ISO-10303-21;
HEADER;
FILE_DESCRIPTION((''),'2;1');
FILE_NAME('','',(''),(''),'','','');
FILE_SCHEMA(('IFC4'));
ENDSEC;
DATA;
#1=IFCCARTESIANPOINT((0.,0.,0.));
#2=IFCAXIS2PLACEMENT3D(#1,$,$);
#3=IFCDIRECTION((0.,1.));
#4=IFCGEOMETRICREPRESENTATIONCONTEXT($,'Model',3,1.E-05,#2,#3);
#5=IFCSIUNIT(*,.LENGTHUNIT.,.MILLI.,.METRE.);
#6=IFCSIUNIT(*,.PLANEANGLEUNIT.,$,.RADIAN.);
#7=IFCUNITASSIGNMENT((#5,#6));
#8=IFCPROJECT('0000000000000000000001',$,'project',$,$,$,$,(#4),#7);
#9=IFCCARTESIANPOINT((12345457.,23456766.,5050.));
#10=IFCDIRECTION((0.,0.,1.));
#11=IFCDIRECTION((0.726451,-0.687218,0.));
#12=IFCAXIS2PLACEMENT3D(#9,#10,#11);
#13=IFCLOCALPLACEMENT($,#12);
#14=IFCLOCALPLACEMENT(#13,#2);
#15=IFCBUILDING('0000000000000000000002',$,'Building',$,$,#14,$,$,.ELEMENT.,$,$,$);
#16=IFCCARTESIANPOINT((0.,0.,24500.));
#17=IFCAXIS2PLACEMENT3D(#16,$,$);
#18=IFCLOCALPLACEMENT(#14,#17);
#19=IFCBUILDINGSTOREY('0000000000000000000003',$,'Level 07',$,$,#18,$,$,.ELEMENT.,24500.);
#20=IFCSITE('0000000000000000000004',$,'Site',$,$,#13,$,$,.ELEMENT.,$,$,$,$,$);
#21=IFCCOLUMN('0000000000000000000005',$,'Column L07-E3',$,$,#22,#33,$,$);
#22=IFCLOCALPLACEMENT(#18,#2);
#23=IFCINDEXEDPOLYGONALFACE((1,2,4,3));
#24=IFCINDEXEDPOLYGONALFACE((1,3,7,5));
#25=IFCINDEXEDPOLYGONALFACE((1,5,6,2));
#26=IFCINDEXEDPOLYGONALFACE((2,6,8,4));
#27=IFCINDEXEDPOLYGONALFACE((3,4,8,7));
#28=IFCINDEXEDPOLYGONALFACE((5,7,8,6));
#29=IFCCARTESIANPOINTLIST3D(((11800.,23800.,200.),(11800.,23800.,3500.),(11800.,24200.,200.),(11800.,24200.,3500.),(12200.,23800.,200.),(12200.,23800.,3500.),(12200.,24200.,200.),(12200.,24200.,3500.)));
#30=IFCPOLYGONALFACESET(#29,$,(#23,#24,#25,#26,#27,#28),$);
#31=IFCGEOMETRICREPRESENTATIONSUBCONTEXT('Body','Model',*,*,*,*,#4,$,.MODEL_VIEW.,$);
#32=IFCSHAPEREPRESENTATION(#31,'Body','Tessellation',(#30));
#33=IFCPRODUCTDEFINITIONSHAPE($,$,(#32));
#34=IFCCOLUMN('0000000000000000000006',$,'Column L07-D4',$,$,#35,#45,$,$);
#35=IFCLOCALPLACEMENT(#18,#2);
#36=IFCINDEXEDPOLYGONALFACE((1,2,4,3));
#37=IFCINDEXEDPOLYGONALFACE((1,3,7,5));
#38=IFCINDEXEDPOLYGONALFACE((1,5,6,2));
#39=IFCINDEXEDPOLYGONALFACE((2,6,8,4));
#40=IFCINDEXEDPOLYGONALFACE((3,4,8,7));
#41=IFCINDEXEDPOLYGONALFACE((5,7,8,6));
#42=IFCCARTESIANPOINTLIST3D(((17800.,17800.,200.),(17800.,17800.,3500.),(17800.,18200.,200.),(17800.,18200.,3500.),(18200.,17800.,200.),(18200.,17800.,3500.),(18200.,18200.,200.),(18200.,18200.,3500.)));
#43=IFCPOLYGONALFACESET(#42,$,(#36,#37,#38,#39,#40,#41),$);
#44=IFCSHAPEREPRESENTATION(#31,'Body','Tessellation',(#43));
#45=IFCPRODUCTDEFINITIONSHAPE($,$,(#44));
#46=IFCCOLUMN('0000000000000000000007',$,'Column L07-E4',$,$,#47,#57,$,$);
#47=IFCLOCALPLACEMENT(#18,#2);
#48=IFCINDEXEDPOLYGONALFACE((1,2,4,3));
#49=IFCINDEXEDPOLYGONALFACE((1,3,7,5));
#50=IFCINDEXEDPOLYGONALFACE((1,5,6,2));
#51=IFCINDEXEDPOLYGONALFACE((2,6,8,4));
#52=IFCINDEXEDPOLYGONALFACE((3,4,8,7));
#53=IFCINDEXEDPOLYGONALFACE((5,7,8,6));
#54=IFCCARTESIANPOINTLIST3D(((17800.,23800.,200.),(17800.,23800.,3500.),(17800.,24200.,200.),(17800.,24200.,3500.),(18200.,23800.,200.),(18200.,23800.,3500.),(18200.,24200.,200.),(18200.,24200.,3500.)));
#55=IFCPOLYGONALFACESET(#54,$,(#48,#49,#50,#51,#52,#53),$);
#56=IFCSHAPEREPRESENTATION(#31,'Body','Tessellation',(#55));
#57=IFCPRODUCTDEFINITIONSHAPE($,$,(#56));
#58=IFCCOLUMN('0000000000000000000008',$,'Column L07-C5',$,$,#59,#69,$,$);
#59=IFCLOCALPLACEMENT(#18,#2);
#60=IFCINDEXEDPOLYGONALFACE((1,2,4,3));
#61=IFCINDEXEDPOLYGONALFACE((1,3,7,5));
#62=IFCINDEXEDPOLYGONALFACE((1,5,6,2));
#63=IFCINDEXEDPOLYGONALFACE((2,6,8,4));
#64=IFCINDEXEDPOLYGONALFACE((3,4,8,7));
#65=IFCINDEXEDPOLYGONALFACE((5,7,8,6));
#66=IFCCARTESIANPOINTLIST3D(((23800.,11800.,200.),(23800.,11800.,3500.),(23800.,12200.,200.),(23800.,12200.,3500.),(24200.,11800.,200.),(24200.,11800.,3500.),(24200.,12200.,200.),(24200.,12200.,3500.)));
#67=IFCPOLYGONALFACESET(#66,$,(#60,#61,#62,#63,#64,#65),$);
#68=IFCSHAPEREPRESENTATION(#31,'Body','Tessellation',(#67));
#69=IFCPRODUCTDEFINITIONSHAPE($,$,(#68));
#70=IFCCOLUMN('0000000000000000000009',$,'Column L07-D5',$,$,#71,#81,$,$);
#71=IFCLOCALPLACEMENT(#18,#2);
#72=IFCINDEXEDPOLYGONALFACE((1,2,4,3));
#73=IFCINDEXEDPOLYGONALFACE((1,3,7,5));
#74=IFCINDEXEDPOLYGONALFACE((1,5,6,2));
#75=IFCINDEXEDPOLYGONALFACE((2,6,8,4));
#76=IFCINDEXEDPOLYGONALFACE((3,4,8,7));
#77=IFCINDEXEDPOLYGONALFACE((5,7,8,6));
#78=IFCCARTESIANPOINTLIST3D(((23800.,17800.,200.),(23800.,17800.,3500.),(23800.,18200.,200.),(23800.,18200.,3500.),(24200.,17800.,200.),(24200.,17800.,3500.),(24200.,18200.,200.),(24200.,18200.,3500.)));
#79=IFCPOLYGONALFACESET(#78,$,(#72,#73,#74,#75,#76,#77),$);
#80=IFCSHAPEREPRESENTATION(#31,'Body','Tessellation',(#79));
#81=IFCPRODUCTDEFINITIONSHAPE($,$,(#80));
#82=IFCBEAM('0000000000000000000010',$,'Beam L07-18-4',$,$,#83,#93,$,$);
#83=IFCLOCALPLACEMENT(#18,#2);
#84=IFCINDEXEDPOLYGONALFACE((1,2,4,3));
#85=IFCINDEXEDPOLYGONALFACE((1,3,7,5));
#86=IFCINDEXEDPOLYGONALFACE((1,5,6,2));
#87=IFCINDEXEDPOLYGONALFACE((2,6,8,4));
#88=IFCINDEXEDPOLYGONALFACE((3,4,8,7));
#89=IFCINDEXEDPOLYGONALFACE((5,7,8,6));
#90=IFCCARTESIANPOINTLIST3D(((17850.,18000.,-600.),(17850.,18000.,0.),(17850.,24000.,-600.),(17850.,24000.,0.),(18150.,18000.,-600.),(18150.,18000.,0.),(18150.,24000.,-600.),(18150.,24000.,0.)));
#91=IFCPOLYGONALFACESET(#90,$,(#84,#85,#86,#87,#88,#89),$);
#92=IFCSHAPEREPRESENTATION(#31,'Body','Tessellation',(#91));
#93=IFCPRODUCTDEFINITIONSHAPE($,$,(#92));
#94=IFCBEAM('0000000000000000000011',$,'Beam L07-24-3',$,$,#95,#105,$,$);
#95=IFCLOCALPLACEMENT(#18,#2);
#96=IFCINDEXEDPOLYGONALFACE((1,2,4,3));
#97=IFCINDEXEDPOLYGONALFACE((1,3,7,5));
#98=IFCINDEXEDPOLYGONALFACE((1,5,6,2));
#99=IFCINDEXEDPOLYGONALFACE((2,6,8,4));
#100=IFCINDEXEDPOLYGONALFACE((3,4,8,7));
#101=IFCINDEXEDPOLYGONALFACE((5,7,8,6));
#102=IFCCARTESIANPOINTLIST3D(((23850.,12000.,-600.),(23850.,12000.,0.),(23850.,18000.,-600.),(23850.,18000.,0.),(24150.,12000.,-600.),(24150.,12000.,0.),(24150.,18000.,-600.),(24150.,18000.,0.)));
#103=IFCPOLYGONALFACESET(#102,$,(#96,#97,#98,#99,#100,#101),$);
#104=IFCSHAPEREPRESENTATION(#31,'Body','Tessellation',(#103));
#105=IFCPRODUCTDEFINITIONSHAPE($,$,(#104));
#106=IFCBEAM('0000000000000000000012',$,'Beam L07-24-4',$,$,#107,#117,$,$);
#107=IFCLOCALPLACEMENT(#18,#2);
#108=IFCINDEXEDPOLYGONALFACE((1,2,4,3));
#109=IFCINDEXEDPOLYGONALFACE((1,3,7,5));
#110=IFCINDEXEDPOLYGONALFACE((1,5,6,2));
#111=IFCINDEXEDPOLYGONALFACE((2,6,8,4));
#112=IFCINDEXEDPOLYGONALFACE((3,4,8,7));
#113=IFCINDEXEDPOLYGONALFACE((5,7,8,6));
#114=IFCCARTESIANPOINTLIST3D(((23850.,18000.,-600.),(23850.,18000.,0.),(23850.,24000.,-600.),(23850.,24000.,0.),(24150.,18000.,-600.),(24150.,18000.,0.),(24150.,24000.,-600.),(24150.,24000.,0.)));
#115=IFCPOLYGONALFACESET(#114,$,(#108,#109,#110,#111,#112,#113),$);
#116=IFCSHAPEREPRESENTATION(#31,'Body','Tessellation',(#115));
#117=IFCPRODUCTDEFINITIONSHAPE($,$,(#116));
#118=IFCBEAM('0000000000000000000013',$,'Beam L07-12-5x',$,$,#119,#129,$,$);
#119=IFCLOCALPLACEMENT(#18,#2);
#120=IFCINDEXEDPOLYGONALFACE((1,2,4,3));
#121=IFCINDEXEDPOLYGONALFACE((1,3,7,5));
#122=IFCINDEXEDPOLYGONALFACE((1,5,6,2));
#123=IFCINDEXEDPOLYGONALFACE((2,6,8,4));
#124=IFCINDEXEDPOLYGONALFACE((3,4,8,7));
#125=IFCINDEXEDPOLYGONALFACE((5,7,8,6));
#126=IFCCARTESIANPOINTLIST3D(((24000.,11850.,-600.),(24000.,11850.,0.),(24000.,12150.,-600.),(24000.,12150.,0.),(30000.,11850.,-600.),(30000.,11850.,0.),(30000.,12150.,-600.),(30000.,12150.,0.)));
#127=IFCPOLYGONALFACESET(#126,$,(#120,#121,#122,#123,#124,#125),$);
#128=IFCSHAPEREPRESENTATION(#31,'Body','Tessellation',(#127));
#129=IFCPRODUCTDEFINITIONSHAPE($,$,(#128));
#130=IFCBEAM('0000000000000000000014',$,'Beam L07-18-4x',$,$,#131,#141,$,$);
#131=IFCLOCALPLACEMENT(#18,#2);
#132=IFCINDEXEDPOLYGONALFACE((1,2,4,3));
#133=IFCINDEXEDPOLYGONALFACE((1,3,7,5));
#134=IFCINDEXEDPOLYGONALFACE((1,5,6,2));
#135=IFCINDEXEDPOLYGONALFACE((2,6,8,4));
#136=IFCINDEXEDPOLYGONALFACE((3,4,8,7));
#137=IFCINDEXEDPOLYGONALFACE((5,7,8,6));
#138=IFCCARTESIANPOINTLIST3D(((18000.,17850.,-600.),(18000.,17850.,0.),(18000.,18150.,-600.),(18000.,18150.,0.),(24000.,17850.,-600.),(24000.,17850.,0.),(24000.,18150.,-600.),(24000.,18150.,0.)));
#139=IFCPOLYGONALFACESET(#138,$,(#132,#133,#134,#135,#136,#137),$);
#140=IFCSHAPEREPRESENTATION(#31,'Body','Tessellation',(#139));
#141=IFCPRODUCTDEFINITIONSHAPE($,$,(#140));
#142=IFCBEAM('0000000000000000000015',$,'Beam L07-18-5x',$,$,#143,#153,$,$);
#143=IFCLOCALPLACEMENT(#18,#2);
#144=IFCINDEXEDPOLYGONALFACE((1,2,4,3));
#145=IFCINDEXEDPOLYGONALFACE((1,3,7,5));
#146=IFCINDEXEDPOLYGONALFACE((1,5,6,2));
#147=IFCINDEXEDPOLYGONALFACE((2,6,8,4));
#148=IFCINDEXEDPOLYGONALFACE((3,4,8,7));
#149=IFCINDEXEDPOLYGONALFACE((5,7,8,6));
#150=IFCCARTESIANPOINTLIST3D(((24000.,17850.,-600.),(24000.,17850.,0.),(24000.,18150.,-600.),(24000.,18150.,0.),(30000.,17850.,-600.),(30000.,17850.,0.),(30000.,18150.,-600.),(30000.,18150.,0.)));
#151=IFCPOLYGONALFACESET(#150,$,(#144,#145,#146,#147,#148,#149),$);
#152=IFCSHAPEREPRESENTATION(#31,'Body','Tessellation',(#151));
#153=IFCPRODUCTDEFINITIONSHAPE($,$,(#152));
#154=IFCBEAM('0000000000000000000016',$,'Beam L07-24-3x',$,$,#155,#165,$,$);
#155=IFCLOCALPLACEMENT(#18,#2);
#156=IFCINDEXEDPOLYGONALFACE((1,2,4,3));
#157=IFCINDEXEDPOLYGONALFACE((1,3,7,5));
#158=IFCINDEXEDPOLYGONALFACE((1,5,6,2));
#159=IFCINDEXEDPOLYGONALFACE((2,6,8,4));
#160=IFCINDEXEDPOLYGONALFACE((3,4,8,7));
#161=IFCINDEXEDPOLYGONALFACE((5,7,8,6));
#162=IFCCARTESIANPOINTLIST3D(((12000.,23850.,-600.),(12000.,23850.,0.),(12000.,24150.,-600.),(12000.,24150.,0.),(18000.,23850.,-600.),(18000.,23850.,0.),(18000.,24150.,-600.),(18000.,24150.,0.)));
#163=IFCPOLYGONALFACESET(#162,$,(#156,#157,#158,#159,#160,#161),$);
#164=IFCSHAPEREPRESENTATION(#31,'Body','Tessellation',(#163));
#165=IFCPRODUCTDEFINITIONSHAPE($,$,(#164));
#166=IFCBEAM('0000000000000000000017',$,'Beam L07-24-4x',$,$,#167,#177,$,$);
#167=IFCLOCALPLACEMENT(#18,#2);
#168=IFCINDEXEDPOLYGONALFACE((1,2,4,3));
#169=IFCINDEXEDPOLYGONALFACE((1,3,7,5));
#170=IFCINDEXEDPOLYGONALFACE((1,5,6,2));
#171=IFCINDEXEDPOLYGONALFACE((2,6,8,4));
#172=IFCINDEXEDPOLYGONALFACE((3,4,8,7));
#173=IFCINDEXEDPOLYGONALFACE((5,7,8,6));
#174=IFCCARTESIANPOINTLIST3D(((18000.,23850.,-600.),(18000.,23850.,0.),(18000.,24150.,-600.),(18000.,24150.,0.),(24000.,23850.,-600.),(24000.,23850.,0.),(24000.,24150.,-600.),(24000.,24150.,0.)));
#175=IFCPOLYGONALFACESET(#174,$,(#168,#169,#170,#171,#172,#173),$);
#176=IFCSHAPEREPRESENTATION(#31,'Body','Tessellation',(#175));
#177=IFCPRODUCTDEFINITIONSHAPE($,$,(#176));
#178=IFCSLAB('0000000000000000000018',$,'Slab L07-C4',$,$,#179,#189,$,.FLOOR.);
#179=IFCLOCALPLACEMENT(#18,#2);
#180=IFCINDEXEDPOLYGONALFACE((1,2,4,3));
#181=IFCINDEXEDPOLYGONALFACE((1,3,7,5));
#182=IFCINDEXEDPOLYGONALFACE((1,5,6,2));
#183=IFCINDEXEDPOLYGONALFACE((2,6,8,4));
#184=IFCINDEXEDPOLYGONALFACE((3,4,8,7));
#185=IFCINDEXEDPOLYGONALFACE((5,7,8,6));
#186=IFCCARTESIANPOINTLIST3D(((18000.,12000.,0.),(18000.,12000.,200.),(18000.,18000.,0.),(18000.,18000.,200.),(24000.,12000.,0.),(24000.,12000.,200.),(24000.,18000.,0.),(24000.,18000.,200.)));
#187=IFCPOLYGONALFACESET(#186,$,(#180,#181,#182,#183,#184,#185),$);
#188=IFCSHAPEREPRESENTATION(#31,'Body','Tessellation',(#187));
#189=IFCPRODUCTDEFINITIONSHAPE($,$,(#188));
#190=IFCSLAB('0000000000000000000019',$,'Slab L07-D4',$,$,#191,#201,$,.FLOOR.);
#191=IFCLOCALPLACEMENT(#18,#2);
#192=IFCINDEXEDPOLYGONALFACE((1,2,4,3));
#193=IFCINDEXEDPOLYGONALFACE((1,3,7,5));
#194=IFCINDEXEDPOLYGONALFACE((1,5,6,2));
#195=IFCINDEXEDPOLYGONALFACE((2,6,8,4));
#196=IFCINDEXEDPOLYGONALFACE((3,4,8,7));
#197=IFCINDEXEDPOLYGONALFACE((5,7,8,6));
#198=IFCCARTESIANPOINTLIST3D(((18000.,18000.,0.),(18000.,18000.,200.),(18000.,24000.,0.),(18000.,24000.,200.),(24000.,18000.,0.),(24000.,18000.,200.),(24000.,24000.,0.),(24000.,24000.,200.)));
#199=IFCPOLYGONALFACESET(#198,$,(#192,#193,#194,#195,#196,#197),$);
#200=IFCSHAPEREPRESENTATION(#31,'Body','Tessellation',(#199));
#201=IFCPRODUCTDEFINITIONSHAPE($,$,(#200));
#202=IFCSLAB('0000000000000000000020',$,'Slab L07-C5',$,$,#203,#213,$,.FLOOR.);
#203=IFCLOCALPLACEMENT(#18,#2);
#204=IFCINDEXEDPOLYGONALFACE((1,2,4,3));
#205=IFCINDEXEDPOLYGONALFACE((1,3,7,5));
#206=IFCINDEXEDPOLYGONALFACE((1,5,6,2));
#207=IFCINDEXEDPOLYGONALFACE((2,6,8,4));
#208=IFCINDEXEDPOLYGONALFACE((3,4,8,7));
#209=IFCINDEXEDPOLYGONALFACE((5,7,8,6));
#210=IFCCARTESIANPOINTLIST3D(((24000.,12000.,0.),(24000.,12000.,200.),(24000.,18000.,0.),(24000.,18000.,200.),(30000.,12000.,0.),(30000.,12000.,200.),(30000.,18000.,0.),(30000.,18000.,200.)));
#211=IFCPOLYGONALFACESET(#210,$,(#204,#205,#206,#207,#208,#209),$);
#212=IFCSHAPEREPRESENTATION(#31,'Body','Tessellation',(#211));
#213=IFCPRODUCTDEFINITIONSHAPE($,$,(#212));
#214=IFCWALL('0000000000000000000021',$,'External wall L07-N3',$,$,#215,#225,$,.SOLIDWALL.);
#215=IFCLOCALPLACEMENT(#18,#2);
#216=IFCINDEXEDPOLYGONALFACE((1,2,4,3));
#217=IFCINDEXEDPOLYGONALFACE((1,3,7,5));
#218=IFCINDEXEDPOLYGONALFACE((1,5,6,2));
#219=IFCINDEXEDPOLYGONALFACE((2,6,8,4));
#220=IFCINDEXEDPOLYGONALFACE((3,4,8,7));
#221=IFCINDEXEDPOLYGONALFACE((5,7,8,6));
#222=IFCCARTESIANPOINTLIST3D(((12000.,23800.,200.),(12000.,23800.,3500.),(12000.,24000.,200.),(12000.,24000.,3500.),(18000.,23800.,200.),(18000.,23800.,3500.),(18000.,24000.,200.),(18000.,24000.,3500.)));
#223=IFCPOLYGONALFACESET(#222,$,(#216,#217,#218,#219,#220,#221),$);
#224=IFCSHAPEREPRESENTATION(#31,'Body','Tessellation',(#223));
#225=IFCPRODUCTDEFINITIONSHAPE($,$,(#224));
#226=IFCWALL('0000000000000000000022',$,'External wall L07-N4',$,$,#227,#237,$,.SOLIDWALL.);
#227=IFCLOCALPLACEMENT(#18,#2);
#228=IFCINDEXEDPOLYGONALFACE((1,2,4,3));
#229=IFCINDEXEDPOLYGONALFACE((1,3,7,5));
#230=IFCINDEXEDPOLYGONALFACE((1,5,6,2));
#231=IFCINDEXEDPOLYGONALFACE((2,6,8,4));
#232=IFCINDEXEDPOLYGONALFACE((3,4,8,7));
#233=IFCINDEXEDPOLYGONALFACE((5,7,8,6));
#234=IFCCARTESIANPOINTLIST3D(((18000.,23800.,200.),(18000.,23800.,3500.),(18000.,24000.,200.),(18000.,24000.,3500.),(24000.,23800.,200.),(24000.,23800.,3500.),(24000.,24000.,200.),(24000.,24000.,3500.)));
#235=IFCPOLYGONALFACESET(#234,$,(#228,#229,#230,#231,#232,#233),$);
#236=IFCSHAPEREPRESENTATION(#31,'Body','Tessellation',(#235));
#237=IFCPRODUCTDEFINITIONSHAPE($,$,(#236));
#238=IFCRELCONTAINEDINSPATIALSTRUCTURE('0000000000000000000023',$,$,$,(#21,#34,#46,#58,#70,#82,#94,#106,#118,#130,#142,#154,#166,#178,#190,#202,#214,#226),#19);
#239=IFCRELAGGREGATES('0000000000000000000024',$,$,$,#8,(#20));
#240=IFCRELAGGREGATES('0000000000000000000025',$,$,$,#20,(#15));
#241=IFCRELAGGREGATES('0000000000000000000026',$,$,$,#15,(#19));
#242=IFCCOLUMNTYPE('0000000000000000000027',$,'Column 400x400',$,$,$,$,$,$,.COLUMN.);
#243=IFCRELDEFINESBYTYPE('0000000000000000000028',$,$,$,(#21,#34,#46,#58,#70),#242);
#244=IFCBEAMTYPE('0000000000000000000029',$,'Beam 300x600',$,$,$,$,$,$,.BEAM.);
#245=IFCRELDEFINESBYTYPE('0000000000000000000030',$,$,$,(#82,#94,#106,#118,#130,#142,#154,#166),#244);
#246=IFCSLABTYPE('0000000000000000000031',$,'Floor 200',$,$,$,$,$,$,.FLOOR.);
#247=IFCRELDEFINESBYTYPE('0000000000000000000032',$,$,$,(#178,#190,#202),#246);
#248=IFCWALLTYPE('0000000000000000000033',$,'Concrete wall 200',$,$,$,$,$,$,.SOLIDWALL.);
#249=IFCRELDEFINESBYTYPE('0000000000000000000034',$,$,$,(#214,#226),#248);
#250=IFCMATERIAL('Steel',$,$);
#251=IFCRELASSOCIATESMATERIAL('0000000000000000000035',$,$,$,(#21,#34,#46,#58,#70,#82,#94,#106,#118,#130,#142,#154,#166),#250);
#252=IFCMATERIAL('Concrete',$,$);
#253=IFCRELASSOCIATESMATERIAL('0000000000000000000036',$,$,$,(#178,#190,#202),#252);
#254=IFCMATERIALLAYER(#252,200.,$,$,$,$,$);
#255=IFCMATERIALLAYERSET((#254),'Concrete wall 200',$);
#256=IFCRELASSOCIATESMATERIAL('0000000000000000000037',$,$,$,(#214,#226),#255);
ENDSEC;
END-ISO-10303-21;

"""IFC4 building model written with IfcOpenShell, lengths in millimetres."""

from ifc_helpers import new_model, si_unit, direction, frame, origin, place, context, subcontext, project, spatial, rectangle, extrude, material, layer, layer_set, layer_usage, type_object, element, save


model = new_model("IFC4")

# Units and contexts
model_context = context("Model", 3, precision=1e-05, world=origin(), true_north=direction((0.0, 1.0)))
body_context = subcontext(model_context, "Body", "Model", "MODEL_VIEW")
ifc_project = project(units=[si_unit("LENGTHUNIT", "METRE", prefix="MILLI"), si_unit("PLANEANGLEUNIT", "RADIAN")], contexts=[model_context])

# Site, building, storey
site_placement = place(None, frame((12345457.0, 23456766.0, 5050.0), z_axis=(0.0, 0.0, 1.0), x_axis=(0.726451, -0.687218, 0.0)))
site = spatial("IfcSite", under=ifc_project, at=site_placement, Name="Site", CompositionType="ELEMENT")
building_placement = place(site_placement, origin())
building = spatial("IfcBuilding", under=site, at=building_placement, Name="Building", CompositionType="ELEMENT")
storey_placement = place(building_placement, frame((0.0, 0.0, 24500.0)))
storey = spatial("IfcBuildingStorey", under=building, at=storey_placement, Name="Level 07", CompositionType="ELEMENT", Elevation=24500.0)

# Columns
ifc_material_1 = material(Name="Steel")
column_type = type_object("IfcColumnType", Name="Column 400x400", PredefinedType="COLUMN")
for number, where, name in (
    (1, (11800.0, 23800.0, 200.0), "Column L07-E3"),
    (2, (17800.0, 17800.0, 200.0), "Column L07-D4"),
    (3, (17800.0, 23800.0, 200.0), "Column L07-E4"),
    (4, (23800.0, 11800.0, 200.0), "Column L07-C5"),
    (5, (23800.0, 17800.0, 200.0), "Column L07-D5"),
):
    element("IfcColumn", number, at=place(storey_placement, frame(where)), inside=storey, type_object=column_type, material=ifc_material_1, Name=name, context=body_context, shape_type="SweptSolid", body=[
        extrude(rectangle(XDim=400.0, YDim=400.0), frame((200.0, 200.0, 0.0)), (0.0, 0.0, 1.0), 3300.0),
    ])

# Beams
beam_type = type_object("IfcBeamType", Name="Beam 300x600", PredefinedType="BEAM")
for number, where, name in (
    (6, (17850.0, 18000.0, -600.0), "Beam L07-18-4"),
    (7, (23850.0, 12000.0, -600.0), "Beam L07-24-3"),
    (8, (23850.0, 18000.0, -600.0), "Beam L07-24-4"),
):
    element("IfcBeam", number, at=place(storey_placement, frame(where)), inside=storey, type_object=beam_type, material=ifc_material_1, Name=name, context=body_context, shape_type="SweptSolid", body=[
        extrude(rectangle(XDim=300.0, YDim=6000.0), frame((150.0, 3000.0, 0.0)), (0.0, 0.0, 1.0), 600.0),
    ])
for number, where, name in (
    (9, (24000.0, 11850.0, -600.0), "Beam L07-12-5x"),
    (10, (18000.0, 17850.0, -600.0), "Beam L07-18-4x"),
    (11, (24000.0, 17850.0, -600.0), "Beam L07-18-5x"),
    (12, (12000.0, 23850.0, -600.0), "Beam L07-24-3x"),
    (13, (18000.0, 23850.0, -600.0), "Beam L07-24-4x"),
):
    element("IfcBeam", number, at=place(storey_placement, frame(where)), inside=storey, type_object=beam_type, material=ifc_material_1, Name=name, context=body_context, shape_type="SweptSolid", body=[
        extrude(rectangle(XDim=6000.0, YDim=300.0), frame((3000.0, 150.0, 0.0)), (0.0, 0.0, 1.0), 600.0),
    ])

# Slabs
ifc_material_2 = material(Name="Concrete")
slab_type = type_object("IfcSlabType", Name="Floor 200", PredefinedType="FLOOR")
for number, where, name in (
    (14, (18000.0, 12000.0, 0.0), "Slab L07-C4"),
    (15, (18000.0, 18000.0, 0.0), "Slab L07-D4"),
    (16, (24000.0, 12000.0, 0.0), "Slab L07-C5"),
):
    element("IfcSlab", number, at=place(storey_placement, frame(where)), inside=storey, type_object=slab_type, material=ifc_material_2, Name=name, PredefinedType="FLOOR", context=body_context, shape_type="SweptSolid", body=[
        extrude(rectangle(XDim=6000.0, YDim=6000.0), frame((3000.0, 3000.0, 0.0)), (0.0, 0.0, 1.0), 200.0),
    ])

# Walls
ifc_layer_1 = layer(ifc_material_2, 200.0)
ifc_layer_set_1 = layer_set([ifc_layer_1], Name="Concrete wall 200")
ifc_layer_usage_1 = layer_usage(ifc_layer_set_1, "AXIS2", "POSITIVE", 0.0)
wall_type_1 = type_object("IfcWallType", Name="Concrete wall 200", PredefinedType="SOLIDWALL")
for number, where, name in (
    (17, (12000.0, 23800.0, 200.0), "External wall L07-N3"),
    (18, (18000.0, 23800.0, 200.0), "External wall L07-N4"),
):
    element("IfcWall", number, at=place(storey_placement, frame(where)), inside=storey, type_object=wall_type_1, material=ifc_layer_usage_1, Name=name, PredefinedType="SOLIDWALL", context=body_context, shape_type="SweptSolid", body=[
        extrude(rectangle(XDim=6000.0, YDim=200.0), frame((3000.0, 100.0, 0.0)), (0.0, 0.0, 1.0), 3300.0),
    ])

save(model, "model.ifc")
